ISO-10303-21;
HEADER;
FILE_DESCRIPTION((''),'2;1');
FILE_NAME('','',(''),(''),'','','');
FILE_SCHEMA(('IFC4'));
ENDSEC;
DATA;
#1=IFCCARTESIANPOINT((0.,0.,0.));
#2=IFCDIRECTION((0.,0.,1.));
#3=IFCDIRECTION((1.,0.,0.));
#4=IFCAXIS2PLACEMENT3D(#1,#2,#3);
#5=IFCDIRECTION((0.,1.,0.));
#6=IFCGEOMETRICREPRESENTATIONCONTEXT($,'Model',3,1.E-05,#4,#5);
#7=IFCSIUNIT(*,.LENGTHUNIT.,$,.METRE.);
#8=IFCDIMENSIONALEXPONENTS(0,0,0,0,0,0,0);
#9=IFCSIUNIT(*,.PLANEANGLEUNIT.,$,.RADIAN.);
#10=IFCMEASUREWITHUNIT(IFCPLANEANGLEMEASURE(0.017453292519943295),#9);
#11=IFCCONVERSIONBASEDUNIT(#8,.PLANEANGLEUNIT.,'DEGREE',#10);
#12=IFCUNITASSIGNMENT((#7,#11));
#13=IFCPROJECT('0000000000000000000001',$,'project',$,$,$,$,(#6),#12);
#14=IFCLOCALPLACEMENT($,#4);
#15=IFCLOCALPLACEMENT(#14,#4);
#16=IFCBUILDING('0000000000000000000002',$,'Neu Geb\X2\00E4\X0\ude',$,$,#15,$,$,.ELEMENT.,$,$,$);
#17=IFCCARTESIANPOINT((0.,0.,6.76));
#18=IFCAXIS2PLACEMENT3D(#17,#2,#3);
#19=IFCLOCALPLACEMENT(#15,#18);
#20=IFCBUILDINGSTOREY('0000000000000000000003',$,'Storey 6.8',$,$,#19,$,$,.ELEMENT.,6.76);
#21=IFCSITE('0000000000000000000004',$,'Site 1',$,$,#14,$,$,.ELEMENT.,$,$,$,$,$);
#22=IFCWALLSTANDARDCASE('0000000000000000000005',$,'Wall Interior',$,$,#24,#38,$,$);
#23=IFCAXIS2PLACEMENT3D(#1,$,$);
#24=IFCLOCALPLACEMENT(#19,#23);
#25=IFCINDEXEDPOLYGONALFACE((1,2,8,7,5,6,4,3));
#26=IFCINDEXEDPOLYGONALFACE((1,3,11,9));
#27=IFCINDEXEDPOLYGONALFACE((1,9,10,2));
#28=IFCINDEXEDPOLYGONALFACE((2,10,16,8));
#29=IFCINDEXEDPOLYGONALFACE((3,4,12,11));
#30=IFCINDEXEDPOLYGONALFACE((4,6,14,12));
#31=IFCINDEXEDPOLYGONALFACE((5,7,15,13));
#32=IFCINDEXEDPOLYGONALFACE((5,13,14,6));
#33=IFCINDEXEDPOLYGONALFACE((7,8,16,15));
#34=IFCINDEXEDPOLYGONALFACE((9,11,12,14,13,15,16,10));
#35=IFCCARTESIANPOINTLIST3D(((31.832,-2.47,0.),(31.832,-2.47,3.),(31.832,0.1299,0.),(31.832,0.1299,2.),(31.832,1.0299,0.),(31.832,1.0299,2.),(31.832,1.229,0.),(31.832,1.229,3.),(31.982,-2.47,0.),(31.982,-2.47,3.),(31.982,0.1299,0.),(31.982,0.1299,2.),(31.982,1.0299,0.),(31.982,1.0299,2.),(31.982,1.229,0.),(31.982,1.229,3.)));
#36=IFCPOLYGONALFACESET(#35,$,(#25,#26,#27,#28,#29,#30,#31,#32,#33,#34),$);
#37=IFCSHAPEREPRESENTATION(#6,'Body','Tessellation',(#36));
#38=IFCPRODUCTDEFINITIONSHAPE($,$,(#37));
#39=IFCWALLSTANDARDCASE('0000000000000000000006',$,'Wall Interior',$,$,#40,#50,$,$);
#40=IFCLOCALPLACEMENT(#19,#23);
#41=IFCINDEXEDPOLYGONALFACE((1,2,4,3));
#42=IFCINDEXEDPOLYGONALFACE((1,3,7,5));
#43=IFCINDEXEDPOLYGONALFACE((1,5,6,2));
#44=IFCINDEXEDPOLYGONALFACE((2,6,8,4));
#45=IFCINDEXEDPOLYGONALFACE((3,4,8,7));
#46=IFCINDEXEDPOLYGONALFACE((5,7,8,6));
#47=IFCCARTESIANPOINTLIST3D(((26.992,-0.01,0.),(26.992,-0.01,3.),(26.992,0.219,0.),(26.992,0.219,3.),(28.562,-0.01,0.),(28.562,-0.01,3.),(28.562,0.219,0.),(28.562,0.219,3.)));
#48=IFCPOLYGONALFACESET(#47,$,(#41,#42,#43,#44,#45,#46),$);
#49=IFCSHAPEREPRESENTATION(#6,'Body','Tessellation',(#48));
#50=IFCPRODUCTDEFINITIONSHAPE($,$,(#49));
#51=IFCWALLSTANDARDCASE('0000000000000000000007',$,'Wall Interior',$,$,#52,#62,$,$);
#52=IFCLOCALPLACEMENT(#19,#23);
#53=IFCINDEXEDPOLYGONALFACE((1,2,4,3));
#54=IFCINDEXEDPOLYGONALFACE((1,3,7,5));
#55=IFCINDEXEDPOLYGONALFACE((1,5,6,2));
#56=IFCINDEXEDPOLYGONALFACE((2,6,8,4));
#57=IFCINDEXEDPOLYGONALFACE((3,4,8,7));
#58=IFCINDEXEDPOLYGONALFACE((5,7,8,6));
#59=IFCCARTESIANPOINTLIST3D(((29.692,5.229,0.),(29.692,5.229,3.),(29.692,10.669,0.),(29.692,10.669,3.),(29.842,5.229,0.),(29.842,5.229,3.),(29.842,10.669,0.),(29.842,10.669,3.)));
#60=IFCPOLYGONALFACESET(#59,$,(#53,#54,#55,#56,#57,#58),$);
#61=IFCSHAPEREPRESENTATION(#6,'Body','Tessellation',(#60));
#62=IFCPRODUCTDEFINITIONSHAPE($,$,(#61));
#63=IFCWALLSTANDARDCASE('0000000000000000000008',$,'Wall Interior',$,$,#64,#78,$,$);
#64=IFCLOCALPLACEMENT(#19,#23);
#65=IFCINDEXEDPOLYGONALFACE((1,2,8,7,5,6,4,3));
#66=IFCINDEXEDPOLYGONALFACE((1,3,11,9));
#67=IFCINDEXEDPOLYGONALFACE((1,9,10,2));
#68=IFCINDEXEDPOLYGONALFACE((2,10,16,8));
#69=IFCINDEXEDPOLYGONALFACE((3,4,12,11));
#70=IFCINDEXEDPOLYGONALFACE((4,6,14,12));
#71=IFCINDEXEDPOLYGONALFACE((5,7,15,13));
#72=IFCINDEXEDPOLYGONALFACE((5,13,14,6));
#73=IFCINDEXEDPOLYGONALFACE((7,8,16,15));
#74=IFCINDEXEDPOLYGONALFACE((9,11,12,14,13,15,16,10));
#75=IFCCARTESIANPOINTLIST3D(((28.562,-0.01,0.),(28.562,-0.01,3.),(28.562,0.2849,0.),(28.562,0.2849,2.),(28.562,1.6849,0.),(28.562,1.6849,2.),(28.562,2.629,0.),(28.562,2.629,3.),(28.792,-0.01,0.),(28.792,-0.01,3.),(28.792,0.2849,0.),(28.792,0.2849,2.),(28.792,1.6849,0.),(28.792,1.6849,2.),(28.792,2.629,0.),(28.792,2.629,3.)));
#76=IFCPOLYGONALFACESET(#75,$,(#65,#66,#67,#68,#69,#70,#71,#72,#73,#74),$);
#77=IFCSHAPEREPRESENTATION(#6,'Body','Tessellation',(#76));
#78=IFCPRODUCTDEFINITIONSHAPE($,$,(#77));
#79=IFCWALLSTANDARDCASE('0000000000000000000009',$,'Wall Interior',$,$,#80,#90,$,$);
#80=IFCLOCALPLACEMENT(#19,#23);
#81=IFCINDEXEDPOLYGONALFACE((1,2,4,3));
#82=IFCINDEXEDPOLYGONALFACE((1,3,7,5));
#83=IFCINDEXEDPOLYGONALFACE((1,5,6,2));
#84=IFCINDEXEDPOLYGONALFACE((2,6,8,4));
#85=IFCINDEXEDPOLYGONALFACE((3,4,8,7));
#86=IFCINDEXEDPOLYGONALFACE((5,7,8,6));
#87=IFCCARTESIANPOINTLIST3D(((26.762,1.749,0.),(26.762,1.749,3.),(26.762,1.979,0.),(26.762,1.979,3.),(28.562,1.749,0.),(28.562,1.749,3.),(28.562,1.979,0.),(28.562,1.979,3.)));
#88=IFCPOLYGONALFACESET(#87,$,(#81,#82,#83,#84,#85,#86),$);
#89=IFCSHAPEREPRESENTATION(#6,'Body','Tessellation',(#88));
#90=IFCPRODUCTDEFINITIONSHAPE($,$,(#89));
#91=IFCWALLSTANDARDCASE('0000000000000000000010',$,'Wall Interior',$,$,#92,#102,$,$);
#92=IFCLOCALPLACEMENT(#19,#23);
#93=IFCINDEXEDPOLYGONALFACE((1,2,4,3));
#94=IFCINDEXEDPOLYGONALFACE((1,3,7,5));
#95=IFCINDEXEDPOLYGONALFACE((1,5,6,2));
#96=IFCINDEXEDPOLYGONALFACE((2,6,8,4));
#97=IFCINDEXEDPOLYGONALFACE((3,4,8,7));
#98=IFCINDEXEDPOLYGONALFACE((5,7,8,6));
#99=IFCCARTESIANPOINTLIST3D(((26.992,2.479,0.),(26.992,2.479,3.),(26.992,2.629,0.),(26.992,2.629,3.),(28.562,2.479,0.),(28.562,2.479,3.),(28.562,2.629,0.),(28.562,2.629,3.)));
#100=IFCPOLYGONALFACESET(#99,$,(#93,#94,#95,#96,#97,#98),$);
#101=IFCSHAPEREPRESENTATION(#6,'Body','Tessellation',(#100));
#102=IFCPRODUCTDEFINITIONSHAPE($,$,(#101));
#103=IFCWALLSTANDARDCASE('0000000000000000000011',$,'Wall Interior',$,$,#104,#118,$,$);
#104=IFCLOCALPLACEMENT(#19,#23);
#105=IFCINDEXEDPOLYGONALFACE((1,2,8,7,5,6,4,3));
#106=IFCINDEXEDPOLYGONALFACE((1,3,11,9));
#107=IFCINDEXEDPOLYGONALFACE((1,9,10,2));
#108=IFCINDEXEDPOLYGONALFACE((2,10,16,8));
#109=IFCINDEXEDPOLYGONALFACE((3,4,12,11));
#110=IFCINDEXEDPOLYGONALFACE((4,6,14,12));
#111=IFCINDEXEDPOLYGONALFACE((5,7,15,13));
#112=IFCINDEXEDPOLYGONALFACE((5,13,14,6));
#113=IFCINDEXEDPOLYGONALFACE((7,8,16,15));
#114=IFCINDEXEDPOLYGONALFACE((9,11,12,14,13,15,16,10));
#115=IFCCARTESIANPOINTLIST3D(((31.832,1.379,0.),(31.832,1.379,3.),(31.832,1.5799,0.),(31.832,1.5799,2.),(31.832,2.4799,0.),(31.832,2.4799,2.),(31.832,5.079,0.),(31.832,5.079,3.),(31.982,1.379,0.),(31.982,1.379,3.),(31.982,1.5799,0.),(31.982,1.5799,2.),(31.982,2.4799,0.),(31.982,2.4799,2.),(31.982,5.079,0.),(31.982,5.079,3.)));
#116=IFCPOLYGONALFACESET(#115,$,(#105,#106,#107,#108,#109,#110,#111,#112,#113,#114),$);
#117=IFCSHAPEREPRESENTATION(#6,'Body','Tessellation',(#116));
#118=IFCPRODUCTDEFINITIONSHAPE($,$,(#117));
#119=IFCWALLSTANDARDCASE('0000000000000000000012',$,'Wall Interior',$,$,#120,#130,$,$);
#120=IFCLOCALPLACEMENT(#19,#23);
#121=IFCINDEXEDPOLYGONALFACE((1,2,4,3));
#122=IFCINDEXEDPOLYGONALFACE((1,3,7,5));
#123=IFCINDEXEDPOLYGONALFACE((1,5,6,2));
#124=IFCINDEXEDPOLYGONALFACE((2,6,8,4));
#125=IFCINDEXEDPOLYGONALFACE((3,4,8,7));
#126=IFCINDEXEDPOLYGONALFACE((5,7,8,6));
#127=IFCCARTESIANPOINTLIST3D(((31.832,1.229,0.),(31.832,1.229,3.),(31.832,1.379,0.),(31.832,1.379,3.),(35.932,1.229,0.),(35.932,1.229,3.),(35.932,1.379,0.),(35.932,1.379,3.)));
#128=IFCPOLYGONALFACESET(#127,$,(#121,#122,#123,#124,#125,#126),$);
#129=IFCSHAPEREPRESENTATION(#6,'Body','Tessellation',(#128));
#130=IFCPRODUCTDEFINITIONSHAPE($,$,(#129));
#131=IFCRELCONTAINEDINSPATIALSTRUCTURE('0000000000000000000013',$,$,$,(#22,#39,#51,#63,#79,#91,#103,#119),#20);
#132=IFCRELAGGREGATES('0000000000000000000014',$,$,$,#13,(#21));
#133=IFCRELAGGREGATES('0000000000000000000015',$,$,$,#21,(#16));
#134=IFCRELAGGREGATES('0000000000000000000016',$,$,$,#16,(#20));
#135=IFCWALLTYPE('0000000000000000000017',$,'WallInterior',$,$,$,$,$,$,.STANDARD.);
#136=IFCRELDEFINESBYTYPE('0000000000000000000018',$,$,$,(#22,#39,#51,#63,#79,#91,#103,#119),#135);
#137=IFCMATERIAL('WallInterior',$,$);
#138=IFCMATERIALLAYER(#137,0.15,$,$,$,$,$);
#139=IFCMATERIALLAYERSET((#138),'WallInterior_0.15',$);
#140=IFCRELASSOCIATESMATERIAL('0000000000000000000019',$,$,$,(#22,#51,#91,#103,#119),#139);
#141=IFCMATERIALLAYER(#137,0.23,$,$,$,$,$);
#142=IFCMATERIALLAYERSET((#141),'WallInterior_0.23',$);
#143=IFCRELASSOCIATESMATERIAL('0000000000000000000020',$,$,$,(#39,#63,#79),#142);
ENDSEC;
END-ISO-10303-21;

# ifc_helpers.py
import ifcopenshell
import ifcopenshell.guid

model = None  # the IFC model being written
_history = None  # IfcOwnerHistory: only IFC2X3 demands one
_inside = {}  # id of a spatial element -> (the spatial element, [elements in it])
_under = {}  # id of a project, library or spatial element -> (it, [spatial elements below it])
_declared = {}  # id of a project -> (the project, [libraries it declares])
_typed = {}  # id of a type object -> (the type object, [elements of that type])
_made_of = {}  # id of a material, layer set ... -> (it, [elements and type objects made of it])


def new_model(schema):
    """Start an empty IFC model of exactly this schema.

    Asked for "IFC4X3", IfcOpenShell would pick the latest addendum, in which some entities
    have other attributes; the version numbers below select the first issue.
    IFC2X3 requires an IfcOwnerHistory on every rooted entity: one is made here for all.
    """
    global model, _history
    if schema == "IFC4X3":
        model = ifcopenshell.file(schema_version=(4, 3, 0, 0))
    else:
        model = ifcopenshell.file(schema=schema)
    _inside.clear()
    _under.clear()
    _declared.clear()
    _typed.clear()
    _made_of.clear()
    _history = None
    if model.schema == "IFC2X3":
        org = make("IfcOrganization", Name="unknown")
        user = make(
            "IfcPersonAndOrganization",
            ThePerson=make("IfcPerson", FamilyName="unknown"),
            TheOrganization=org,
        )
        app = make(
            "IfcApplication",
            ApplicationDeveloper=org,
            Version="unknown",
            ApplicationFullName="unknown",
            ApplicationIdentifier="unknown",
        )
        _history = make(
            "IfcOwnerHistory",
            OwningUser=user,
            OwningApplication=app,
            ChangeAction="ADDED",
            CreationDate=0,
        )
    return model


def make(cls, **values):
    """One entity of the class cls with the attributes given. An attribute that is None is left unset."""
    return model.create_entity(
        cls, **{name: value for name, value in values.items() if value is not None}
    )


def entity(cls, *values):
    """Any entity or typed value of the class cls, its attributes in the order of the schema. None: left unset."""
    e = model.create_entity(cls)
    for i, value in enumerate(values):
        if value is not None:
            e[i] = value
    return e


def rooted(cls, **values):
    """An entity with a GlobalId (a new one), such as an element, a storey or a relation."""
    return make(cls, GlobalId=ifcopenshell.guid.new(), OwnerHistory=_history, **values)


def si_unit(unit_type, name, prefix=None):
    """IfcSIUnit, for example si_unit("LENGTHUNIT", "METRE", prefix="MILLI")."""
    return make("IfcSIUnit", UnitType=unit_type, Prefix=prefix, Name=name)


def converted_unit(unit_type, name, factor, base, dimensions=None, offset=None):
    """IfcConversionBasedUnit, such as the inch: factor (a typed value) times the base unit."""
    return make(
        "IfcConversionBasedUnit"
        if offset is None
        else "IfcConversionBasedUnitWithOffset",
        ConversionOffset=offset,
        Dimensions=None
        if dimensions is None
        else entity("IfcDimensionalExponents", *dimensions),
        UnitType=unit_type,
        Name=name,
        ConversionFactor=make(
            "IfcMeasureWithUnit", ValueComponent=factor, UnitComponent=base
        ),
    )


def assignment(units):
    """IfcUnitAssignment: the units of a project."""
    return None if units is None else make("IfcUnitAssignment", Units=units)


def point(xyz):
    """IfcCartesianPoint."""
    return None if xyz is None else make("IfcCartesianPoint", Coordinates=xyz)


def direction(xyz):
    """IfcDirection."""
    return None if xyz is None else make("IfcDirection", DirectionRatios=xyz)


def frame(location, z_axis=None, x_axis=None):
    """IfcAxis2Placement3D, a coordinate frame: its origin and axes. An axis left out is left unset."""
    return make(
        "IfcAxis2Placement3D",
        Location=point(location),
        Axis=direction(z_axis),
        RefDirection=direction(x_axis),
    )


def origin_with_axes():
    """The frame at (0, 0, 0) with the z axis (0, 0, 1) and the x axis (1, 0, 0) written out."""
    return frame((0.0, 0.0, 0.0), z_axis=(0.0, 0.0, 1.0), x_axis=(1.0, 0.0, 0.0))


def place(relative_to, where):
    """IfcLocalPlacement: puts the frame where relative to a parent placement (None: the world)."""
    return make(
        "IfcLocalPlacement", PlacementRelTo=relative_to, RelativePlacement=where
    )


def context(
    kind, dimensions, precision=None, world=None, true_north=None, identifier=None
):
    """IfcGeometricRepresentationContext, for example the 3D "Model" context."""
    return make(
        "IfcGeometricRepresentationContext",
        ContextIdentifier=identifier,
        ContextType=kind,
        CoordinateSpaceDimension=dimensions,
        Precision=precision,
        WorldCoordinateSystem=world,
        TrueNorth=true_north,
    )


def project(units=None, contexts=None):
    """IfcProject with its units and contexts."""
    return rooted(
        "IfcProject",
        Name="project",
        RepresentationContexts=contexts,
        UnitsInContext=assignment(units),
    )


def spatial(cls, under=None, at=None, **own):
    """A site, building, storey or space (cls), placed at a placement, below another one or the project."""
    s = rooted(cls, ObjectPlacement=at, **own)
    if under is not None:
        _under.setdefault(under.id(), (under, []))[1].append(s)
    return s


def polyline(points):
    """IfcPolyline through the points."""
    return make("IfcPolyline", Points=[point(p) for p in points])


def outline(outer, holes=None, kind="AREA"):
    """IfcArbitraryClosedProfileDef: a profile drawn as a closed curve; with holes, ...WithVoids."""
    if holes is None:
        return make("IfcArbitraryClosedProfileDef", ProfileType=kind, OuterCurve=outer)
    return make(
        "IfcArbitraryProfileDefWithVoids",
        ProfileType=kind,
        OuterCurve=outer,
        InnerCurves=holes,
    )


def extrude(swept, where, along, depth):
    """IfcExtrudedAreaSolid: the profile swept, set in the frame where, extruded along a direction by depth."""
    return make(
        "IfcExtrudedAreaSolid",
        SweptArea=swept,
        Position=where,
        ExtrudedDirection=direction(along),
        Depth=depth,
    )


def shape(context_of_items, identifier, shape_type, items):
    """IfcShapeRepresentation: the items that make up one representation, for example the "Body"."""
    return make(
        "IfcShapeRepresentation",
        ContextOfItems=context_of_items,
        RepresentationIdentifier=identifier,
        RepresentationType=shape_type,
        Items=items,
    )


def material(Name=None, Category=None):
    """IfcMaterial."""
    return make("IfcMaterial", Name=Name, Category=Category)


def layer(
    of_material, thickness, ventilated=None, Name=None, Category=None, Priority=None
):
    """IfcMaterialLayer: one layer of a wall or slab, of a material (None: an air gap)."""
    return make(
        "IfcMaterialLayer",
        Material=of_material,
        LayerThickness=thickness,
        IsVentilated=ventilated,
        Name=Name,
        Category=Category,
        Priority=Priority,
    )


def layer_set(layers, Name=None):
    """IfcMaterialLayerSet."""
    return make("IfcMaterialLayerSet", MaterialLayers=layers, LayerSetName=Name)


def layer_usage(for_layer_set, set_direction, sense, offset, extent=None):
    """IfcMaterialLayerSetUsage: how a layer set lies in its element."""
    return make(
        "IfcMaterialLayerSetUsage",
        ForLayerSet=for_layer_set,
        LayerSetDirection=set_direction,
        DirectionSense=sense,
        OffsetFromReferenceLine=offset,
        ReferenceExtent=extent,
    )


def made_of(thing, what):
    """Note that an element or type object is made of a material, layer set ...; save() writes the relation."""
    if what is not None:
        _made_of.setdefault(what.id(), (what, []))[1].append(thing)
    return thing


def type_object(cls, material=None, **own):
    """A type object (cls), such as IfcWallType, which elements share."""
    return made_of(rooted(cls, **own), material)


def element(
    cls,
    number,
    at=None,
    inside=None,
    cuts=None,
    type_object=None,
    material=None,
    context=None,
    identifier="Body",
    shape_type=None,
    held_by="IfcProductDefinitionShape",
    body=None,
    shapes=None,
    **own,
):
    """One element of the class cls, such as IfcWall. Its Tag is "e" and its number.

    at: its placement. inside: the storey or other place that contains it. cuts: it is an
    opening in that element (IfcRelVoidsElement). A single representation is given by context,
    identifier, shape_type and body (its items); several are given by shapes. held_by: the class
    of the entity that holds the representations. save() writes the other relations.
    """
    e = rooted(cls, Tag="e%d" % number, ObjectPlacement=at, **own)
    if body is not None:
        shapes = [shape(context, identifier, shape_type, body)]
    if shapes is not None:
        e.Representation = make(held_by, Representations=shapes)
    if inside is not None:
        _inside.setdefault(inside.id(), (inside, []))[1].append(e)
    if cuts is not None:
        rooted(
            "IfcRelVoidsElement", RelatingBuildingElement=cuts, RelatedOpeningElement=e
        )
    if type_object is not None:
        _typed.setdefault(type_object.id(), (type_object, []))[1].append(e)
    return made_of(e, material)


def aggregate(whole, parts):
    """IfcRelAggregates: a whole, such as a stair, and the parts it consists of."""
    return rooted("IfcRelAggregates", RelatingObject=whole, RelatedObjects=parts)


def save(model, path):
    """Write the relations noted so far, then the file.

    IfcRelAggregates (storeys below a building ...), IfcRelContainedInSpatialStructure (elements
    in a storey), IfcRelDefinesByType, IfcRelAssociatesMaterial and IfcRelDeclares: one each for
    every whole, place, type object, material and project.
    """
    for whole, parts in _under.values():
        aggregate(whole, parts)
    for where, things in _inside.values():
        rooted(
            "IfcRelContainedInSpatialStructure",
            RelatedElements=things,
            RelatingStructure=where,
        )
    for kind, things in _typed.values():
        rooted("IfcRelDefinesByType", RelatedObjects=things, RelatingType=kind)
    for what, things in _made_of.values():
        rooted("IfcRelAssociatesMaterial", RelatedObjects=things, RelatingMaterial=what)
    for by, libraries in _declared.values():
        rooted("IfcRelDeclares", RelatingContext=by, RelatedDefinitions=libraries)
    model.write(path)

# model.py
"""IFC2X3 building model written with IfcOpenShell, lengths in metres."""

from ifc_helpers import new_model, entity, si_unit, converted_unit, direction, frame, origin_with_axes, place, context, project, spatial, polyline, outline, extrude, material, layer, layer_set, layer_usage, type_object, element, save


model = new_model("IFC2X3")

# Units and contexts
model_context = context("Model", 3, precision=1e-05, world=origin_with_axes(), true_north=direction((0.0, 1.0, 0.0)))
ifc_project = project(units=[si_unit("LENGTHUNIT", "METRE"), converted_unit("PLANEANGLEUNIT", "DEGREE", entity("IfcPlaneAngleMeasure", 0.017453292519943295), si_unit("PLANEANGLEUNIT", "RADIAN"), dimensions=[0, 0, 0, 0, 0, 0, 0])], contexts=[model_context])

# Site, building, storey
site_placement = place(None, origin_with_axes())
site = spatial("IfcSite", under=ifc_project, at=site_placement, Name="Site 1", CompositionType="ELEMENT")
building_placement = place(site_placement, origin_with_axes())
building = spatial("IfcBuilding", under=site, at=building_placement, Name="Neu Gebäude", CompositionType="ELEMENT")
storey_placement = place(building_placement, frame((0.0, 0.0, 6.76), z_axis=(0.0, 0.0, 1.0), x_axis=(1.0, 0.0, 0.0)))
storey = spatial("IfcBuildingStorey", under=building, at=storey_placement, Name="Storey 6.8", CompositionType="ELEMENT", Elevation=6.76)

# Wall, opening
ifc_material_1 = material(Name="WallInterior")
ifc_layer_1 = layer(ifc_material_1, 0.15)
ifc_layer_set_1 = layer_set([ifc_layer_1], Name="WallInterior_0.15")
ifc_layer_usage_1 = layer_usage(ifc_layer_set_1, "AXIS2", "POSITIVE", -0.075)
wall_type_1 = type_object("IfcWallType", Name="WallInterior", PredefinedType="STANDARD")
wall_1_placement = place(storey_placement, frame((31.907, -2.47, 0.0), z_axis=(0.0, 0.0, 1.0), x_axis=(0.0, 1.0, 0.0)))
wall_1 = element("IfcWallStandardCase", 1, at=wall_1_placement, inside=storey, type_object=wall_type_1, material=ifc_layer_usage_1, Name="Wall Interior", context=model_context, shape_type="SweptSolid", body=[
    extrude(outline(polyline([(3.699, -0.075), (3.699, 0.075), (0.0, 0.075), (0.0, -0.075), (3.699, -0.075)])), origin_with_axes(), (0.0, 0.0, 1.0), 3.0),
])
opening_1_placement = place(wall_1_placement, frame((3.0499, 0.0, 0.0), z_axis=(0.0, 0.0, 1.0), x_axis=(1.0, 0.0, 0.0)))
element("IfcOpeningElement", 2, at=opening_1_placement, cuts=wall_1, context=model_context, shape_type="SweptSolid", body=[
    extrude(outline(polyline([(-0.45, 0.172), (0.45, 0.172), (0.45, -0.172), (-0.45, -0.172), (-0.45, 0.172)])), origin_with_axes(), (0.0, 0.0, 1.0), 2.0),
])

# Walls
ifc_layer_2 = layer(ifc_material_1, 0.23)
ifc_layer_set_2 = layer_set([ifc_layer_2], Name="WallInterior_0.23")
ifc_layer_usage_2 = layer_usage(ifc_layer_set_2, "AXIS2", "POSITIVE", -0.115)
wall_2_placement = place(storey_placement, frame((28.562, 0.1045, 0.0), z_axis=(0.0, 0.0, 1.0), x_axis=(-1.0, 0.0, 0.0)))
element("IfcWallStandardCase", 3, at=wall_2_placement, inside=storey, type_object=wall_type_1, material=ifc_layer_usage_2, Name="Wall Interior", context=model_context, shape_type="SweptSolid", body=[
    extrude(outline(polyline([(0.0, -0.1145), (1.57, -0.1145), (1.57, 0.1145), (0.0, 0.1145), (0.0, -0.1145)])), origin_with_axes(), (0.0, 0.0, 1.0), 3.0),
])
wall_3_placement = place(storey_placement, frame((29.767, 5.229, 0.0), z_axis=(0.0, 0.0, 1.0), x_axis=(0.0, 1.0, 0.0)))
element("IfcWallStandardCase", 4, at=wall_3_placement, inside=storey, type_object=wall_type_1, material=ifc_layer_usage_1, Name="Wall Interior", context=model_context, shape_type="SweptSolid", body=[
    extrude(outline(polyline([(5.44, -0.075), (5.44, 0.075), (0.0, 0.075), (0.0, -0.075), (5.44, -0.075)])), origin_with_axes(), (0.0, 0.0, 1.0), 3.0),
])

# Wall, opening
wall_4_placement = place(storey_placement, frame((28.677, -0.01, 0.0), z_axis=(0.0, 0.0, 1.0), x_axis=(0.0, 1.0, 0.0)))
wall_4 = element("IfcWallStandardCase", 5, at=wall_4_placement, inside=storey, type_object=wall_type_1, material=ifc_layer_usage_2, Name="Wall Interior", context=model_context, shape_type="SweptSolid", body=[
    extrude(outline(polyline([(2.639, -0.115), (2.639, 0.115), (0.0, 0.115), (0.0, -0.115), (2.639, -0.115)])), origin_with_axes(), (0.0, 0.0, 1.0), 3.0),
])
opening_2_placement = place(wall_4_placement, frame((0.9949, 0.0, 0.0), z_axis=(0.0, 0.0, 1.0), x_axis=(1.0, 0.0, 0.0)))
element("IfcOpeningElement", 6, at=opening_2_placement, cuts=wall_4, context=model_context, shape_type="SweptSolid", body=[
    extrude(outline(polyline([(-0.7, 0.252), (0.7, 0.252), (0.7, -0.252), (-0.7, -0.252), (-0.7, 0.252)])), origin_with_axes(), (0.0, 0.0, 1.0), 2.0),
])

# Walls
wall_5_placement = place(storey_placement, frame((28.562, 1.864, 0.0), z_axis=(0.0, 0.0, 1.0), x_axis=(-1.0, 0.0, 0.0)))
element("IfcWallStandardCase", 7, at=wall_5_placement, inside=storey, type_object=wall_type_1, material=ifc_layer_usage_2, Name="Wall Interior", context=model_context, shape_type="SweptSolid", body=[
    extrude(outline(polyline([(0.0, -0.115), (1.8, -0.115), (1.8, 0.115), (0.0, 0.115), (0.0, -0.115)])), origin_with_axes(), (0.0, 0.0, 1.0), 3.0),
])
wall_6_placement = place(storey_placement, frame((28.562, 2.554, 0.0), z_axis=(0.0, 0.0, 1.0), x_axis=(-1.0, 0.0, 0.0)))
element("IfcWallStandardCase", 8, at=wall_6_placement, inside=storey, type_object=wall_type_1, material=ifc_layer_usage_1, Name="Wall Interior", context=model_context, shape_type="SweptSolid", body=[
    extrude(outline(polyline([(0.0, -0.075), (1.57, -0.075), (1.57, 0.075), (0.0, 0.075), (0.0, -0.075)])), origin_with_axes(), (0.0, 0.0, 1.0), 3.0),
])

# Wall, opening
wall_7_placement = place(storey_placement, frame((31.907, 1.379, 0.0), z_axis=(0.0, 0.0, 1.0), x_axis=(0.0, 1.0, 0.0)))
wall_7 = element("IfcWallStandardCase", 9, at=wall_7_placement, inside=storey, type_object=wall_type_1, material=ifc_layer_usage_1, Name="Wall Interior", context=model_context, shape_type="SweptSolid", body=[
    extrude(outline(polyline([(3.7, -0.075), (3.7, 0.075), (0.0, 0.075), (0.0, -0.075), (3.7, -0.075)])), origin_with_axes(), (0.0, 0.0, 1.0), 3.0),
])
opening_3_placement = place(wall_7_placement, frame((0.6509, 0.0, 0.0), z_axis=(0.0, 0.0, 1.0), x_axis=(1.0, 0.0, 0.0)))
element("IfcOpeningElement", 10, at=opening_3_placement, cuts=wall_7, context=model_context, shape_type="SweptSolid", body=[
    extrude(outline(polyline([(-0.45, 0.172), (0.45, 0.172), (0.45, -0.172), (-0.45, -0.172), (-0.45, 0.172)])), origin_with_axes(), (0.0, 0.0, 1.0), 2.0),
])

# Wall
wall_8_placement = place(storey_placement, frame((35.932, 1.304, 0.0), z_axis=(0.0, 0.0, 1.0), x_axis=(-1.0, 0.0, 0.0)))
element("IfcWallStandardCase", 11, at=wall_8_placement, inside=storey, type_object=wall_type_1, material=ifc_layer_usage_1, Name="Wall Interior", context=model_context, shape_type="SweptSolid", body=[
    extrude(outline(polyline([(0.0, -0.075), (4.1, -0.075), (4.1, 0.075), (0.0, 0.075), (0.0, -0.075)])), origin_with_axes(), (0.0, 0.0, 1.0), 3.0),
])

save(model, "model.ifc")
